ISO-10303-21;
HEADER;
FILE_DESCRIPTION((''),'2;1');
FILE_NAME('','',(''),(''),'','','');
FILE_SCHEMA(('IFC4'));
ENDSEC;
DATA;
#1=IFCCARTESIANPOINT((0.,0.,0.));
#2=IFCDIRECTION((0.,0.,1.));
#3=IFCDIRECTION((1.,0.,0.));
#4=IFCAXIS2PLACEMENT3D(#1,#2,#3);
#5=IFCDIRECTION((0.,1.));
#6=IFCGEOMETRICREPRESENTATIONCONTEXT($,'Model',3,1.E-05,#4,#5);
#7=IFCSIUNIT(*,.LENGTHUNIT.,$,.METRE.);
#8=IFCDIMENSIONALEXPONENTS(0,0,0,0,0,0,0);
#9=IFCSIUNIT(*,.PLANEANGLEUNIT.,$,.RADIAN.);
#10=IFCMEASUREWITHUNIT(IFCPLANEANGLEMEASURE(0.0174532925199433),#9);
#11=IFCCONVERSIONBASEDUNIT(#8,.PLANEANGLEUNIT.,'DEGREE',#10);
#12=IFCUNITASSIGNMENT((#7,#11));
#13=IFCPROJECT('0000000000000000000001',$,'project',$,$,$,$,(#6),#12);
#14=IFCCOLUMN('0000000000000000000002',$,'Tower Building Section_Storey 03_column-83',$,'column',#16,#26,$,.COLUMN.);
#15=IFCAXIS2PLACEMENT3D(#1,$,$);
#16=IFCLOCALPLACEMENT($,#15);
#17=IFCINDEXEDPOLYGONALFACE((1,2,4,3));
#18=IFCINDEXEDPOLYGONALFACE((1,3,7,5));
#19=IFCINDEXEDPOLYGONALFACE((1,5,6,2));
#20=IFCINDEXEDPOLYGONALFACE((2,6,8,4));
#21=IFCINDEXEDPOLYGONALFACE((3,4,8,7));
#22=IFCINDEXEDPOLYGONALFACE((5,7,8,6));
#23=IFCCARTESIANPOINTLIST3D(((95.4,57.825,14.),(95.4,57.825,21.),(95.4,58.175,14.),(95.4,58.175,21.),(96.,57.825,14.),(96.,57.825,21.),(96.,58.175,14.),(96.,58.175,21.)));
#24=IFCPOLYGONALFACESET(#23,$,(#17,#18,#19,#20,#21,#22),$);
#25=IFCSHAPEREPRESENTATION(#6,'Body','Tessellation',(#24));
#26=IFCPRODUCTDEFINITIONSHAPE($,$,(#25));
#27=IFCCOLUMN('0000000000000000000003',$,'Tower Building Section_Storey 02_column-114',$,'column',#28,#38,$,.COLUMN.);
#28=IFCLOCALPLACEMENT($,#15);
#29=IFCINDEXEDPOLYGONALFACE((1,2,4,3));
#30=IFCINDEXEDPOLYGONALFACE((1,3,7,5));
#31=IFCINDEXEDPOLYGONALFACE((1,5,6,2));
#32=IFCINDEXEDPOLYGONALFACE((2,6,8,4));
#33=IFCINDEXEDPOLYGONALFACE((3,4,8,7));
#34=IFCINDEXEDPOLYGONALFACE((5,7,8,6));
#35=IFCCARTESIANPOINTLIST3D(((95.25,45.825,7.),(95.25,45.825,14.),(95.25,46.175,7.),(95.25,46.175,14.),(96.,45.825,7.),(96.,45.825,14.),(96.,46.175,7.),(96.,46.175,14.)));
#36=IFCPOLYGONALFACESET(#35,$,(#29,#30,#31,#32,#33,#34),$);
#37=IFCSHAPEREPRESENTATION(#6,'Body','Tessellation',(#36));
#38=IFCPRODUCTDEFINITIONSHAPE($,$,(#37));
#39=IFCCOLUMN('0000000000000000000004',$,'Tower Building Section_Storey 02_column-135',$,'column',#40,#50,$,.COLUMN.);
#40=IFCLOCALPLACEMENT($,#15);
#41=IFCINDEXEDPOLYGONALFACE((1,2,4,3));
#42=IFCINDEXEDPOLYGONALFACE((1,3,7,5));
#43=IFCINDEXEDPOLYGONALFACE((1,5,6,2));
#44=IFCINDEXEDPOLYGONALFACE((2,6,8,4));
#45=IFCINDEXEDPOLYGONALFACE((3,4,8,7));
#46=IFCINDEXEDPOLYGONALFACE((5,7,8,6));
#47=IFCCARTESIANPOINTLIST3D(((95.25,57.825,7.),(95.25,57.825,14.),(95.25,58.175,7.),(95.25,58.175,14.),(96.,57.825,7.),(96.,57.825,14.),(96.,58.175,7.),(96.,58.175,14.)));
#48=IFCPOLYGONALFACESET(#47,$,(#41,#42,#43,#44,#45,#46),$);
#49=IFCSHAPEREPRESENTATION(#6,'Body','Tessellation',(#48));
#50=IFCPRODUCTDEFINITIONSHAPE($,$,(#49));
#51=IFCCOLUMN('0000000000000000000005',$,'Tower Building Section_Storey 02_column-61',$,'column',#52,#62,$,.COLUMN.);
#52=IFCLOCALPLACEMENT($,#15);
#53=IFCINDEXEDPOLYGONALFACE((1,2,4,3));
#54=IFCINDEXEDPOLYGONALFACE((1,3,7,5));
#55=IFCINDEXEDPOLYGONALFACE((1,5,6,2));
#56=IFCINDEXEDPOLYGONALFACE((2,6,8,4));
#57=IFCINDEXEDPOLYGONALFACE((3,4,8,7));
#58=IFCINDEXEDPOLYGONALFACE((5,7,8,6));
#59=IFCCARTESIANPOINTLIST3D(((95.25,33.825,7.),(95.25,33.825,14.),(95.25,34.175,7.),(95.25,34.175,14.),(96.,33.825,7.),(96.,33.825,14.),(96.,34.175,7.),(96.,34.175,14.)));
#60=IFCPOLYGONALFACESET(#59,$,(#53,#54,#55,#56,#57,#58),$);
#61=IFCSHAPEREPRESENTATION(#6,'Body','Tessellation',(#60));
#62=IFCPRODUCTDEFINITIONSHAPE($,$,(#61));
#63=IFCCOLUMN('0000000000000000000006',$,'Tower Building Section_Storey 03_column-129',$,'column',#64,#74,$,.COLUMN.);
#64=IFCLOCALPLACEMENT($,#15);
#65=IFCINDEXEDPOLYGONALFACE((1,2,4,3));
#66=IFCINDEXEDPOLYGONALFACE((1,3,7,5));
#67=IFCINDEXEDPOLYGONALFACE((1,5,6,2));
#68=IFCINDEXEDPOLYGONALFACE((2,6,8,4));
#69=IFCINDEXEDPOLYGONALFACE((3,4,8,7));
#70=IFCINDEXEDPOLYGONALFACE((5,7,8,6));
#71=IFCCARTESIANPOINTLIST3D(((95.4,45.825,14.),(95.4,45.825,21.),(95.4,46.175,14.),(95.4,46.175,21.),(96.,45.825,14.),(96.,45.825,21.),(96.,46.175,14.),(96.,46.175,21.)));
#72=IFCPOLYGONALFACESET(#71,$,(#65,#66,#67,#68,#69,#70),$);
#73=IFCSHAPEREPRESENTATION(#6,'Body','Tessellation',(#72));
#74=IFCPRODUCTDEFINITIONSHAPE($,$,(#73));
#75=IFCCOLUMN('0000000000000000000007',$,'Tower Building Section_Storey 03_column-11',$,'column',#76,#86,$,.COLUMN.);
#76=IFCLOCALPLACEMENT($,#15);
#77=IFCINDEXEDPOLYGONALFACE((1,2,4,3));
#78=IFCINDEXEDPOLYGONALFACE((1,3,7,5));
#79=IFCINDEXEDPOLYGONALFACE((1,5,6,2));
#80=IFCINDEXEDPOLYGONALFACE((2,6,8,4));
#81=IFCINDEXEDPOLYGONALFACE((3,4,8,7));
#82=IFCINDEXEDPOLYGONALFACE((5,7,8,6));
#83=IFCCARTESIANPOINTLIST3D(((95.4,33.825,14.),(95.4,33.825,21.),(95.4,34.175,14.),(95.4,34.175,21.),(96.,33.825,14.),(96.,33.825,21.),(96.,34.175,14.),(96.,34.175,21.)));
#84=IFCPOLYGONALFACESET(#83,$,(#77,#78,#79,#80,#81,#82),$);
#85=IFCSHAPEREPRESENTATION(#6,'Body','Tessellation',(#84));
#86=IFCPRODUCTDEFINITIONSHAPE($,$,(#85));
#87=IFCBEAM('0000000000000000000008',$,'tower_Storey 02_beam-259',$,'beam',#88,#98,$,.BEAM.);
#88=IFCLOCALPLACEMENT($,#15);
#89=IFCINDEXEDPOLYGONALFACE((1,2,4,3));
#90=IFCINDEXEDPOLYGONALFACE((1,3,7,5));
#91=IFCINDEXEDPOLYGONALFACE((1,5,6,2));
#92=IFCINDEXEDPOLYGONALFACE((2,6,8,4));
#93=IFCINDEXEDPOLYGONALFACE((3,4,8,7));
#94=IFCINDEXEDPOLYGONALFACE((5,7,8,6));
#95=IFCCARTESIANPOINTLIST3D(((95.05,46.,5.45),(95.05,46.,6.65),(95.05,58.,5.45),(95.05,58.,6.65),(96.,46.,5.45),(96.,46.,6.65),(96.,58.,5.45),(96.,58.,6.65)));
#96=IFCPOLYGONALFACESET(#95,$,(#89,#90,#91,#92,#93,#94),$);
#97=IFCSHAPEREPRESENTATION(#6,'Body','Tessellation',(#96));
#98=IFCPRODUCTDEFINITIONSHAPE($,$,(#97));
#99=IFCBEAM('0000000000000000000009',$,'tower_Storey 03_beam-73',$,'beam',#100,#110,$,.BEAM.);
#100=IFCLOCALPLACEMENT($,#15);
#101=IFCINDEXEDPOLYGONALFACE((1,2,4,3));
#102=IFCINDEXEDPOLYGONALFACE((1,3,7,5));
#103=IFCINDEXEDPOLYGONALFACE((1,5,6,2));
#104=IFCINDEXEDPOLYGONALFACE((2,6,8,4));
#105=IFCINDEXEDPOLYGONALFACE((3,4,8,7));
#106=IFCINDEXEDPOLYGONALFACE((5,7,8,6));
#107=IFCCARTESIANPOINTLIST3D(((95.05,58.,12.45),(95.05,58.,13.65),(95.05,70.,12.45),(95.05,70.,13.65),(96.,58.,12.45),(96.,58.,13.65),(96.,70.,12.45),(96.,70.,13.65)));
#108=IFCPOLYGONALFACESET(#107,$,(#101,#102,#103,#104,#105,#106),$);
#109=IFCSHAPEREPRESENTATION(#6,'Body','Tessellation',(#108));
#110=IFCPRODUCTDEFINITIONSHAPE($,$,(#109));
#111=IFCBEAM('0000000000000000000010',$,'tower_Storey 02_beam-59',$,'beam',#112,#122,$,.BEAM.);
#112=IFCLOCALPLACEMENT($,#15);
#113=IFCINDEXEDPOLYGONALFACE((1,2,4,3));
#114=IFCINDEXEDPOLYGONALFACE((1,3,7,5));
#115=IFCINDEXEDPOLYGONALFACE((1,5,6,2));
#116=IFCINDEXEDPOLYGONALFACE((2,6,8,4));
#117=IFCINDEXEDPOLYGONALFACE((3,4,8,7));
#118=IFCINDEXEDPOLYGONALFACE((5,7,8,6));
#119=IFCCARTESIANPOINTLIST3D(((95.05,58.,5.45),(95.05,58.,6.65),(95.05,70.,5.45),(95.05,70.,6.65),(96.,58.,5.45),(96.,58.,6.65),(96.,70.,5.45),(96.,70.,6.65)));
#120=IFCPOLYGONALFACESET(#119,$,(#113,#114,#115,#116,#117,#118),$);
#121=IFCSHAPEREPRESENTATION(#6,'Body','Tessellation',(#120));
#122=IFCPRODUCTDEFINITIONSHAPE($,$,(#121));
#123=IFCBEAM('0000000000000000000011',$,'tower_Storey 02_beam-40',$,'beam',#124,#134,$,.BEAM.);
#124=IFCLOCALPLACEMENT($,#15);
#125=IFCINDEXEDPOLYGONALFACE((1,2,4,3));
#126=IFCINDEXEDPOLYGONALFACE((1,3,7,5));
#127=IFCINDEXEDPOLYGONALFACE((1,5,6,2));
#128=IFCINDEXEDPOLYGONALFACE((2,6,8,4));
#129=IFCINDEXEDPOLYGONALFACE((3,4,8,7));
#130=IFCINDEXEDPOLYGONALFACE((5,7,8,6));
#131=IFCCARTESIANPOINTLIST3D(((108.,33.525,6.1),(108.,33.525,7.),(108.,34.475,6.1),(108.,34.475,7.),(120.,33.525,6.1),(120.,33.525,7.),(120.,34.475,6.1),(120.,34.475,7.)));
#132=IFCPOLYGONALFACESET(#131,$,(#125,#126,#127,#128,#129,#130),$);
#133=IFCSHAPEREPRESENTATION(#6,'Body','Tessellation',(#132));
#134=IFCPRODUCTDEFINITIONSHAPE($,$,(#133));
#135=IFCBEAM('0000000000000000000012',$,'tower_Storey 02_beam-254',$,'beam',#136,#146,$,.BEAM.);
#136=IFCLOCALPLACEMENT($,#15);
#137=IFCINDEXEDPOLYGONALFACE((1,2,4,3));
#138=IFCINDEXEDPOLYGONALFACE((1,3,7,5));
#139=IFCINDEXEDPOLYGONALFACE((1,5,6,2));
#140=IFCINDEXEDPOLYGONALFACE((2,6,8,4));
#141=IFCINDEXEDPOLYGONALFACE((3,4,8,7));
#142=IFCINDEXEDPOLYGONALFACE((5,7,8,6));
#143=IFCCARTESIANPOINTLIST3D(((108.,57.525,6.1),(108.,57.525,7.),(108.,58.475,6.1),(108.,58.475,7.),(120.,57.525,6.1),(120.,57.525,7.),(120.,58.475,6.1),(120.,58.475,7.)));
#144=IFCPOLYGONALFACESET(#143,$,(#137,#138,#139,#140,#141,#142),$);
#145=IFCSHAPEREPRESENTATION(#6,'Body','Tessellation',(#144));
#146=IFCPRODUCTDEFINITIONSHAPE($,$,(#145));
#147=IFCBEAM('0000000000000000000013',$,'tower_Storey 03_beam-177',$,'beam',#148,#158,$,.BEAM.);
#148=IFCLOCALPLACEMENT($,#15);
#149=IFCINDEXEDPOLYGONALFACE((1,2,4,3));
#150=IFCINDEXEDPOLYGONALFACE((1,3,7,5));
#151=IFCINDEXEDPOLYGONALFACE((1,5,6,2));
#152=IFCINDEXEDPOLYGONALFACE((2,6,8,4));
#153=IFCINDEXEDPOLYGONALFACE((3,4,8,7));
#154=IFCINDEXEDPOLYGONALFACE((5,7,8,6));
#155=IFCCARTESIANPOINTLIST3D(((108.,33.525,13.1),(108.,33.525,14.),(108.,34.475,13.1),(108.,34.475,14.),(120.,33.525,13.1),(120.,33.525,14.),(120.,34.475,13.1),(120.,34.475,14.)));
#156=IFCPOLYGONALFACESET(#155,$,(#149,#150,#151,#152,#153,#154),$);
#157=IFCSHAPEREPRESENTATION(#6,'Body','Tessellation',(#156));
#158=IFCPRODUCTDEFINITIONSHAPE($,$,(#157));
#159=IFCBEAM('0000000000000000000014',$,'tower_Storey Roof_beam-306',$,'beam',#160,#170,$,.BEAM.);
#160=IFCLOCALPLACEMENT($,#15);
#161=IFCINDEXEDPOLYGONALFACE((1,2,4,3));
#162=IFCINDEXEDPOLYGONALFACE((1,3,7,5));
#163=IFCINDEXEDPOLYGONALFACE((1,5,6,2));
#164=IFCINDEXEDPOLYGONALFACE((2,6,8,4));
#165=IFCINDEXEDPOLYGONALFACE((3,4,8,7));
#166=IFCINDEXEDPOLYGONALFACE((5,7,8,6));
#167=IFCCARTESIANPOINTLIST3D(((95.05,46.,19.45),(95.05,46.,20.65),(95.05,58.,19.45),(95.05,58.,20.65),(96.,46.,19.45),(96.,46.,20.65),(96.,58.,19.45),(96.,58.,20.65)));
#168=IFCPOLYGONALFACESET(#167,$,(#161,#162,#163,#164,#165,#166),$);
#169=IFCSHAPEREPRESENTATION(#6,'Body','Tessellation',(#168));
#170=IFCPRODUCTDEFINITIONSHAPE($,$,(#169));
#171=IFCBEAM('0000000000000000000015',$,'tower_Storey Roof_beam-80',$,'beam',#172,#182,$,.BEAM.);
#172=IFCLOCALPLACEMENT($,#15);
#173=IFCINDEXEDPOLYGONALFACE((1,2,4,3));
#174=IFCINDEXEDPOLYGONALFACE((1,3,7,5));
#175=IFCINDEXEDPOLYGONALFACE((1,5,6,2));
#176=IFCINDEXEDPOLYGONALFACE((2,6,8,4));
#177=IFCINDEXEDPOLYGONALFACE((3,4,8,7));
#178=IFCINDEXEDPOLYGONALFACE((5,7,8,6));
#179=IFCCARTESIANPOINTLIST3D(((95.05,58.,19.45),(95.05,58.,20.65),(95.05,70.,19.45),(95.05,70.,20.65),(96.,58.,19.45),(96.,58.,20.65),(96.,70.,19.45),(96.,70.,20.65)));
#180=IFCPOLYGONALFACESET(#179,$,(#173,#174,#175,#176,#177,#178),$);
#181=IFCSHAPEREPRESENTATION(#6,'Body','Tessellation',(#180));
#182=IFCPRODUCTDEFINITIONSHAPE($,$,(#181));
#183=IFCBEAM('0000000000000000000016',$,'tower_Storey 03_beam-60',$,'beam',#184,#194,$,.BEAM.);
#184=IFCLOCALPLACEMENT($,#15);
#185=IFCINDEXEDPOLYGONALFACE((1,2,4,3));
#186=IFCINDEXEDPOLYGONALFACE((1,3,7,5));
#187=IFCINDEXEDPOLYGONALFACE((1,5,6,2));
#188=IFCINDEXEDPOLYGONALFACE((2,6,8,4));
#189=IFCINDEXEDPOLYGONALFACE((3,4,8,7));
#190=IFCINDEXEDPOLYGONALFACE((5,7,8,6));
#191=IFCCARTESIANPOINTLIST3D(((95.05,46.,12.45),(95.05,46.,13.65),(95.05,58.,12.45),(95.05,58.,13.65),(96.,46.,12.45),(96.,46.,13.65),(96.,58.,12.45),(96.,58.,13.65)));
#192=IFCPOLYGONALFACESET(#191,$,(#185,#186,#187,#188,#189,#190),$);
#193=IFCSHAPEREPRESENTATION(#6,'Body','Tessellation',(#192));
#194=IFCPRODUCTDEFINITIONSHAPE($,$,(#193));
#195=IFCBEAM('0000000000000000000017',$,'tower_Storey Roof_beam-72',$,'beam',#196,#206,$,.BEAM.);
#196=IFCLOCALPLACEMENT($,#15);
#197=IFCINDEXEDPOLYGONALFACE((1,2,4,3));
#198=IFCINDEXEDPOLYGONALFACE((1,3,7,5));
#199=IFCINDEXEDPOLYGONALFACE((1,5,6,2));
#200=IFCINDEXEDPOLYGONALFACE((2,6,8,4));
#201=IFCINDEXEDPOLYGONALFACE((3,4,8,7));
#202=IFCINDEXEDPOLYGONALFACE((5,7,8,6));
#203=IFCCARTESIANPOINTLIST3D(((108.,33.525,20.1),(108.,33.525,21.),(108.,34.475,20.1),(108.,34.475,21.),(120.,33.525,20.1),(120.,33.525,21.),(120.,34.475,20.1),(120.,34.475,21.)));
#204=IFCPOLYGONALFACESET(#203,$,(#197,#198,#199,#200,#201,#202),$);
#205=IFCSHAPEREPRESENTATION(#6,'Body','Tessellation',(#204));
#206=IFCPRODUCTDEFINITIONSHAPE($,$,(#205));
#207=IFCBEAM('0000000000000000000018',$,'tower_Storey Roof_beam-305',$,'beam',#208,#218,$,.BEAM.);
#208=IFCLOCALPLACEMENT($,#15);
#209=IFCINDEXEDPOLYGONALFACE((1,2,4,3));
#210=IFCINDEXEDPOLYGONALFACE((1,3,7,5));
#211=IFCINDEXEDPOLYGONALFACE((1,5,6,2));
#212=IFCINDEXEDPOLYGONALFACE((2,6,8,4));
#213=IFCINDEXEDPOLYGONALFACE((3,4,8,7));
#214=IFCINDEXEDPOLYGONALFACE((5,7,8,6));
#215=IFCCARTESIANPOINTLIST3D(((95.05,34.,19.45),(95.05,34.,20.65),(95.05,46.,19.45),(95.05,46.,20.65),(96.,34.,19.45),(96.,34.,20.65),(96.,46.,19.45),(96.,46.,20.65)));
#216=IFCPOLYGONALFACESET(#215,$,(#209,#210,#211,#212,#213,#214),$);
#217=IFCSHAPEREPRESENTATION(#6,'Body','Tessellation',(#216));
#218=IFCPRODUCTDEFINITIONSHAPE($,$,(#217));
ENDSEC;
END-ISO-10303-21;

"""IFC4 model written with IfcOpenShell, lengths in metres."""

from ifc_helpers import new_model, entity, si_unit, converted_unit, direction, frame, origin_with_axes, place, context, project, polyline, outline, extrude, element, save


model = new_model("IFC4")

# Units and contexts
model_context = context("Model", 3, precision=1e-05, world=origin_with_axes(), true_north=direction((0.0, 1.0)))
ifc_project = project(units=[si_unit("LENGTHUNIT", "METRE"), converted_unit("PLANEANGLEUNIT", "DEGREE", entity("IfcPlaneAngleMeasure", 0.0174532925199433), si_unit("PLANEANGLEUNIT", "RADIAN"), dimensions=[0, 0, 0, 0, 0, 0, 0])], contexts=[model_context])

# Columns
placement_1 = place(None, origin_with_axes())
placement_2 = place(placement_1, frame((0.0, 0.0, 14.0), z_axis=(0.0, 0.0, 1.0), x_axis=(1.0, 0.0, 0.0)))
column_placement = place(placement_2, frame((95.7, 58.0, 0.0), z_axis=(0.0, 0.0, 1.0), x_axis=(1.0, 0.0, 0.0)))
element("IfcColumn", 1, at=column_placement, Name="Tower Building Section_Storey 03_column-83", ObjectType="column", PredefinedType="COLUMN", context=model_context, body=[
    extrude(outline(polyline([(-0.3, -0.175, 0.0), (0.3, -0.175, 0.0), (0.3, 0.175, 0.0), (-0.3, 0.175, 0.0), (-0.3, -0.175, 0.0)])), origin_with_axes(), (0.0, 0.0, 1.0), 7.0),
])
placement_3 = place(placement_1, frame((0.0, 0.0, 7.0), z_axis=(0.0, 0.0, 1.0), x_axis=(1.0, 0.0, 0.0)))
for number, where, z_axis, x_axis, name in (
    (2, (95.625, 46.0, 0.0), (0.0, 0.0, 1.0), (1.0, 0.0, 0.0), "Tower Building Section_Storey 02_column-114"),
    (3, (95.625, 58.0, 0.0), (0.0, 0.0, 1.0), (1.0, 0.0, 0.0), "Tower Building Section_Storey 02_column-135"),
    (4, (95.625, 34.0, 0.0), (0.0, 0.0, 1.0), (1.0, 0.0, 0.0), "Tower Building Section_Storey 02_column-61"),
):
    element("IfcColumn", number, at=place(placement_3, frame(where, z_axis=z_axis, x_axis=x_axis)), Name=name, ObjectType="column", PredefinedType="COLUMN", context=model_context, body=[
        extrude(outline(polyline([(-0.375, -0.175, 0.0), (0.375, -0.175, 0.0), (0.375, 0.175, 0.0), (-0.375, 0.175, 0.0), (-0.375, -0.175, 0.0)])), origin_with_axes(), (0.0, 0.0, 1.0), 7.0),
    ])
for number, where, z_axis, x_axis, name in (
    (5, (95.7, 46.0, 0.0), (0.0, 0.0, 1.0), (1.0, 0.0, 0.0), "Tower Building Section_Storey 03_column-129"),
    (6, (95.7, 34.0, 0.0), (0.0, 0.0, 1.0), (1.0, 0.0, 0.0), "Tower Building Section_Storey 03_column-11"),
):
    element("IfcColumn", number, at=place(placement_2, frame(where, z_axis=z_axis, x_axis=x_axis)), Name=name, ObjectType="column", PredefinedType="COLUMN", context=model_context, body=[
        extrude(outline(polyline([(-0.3, -0.175, 0.0), (0.3, -0.175, 0.0), (0.3, 0.175, 0.0), (-0.3, 0.175, 0.0), (-0.3, -0.175, 0.0)])), origin_with_axes(), (0.0, 0.0, 1.0), 7.0),
    ])

# Beams
beam_1_placement = place(placement_3, frame((95.525, 46.0, -0.95), z_axis=(0.0, 1.0, 0.0), x_axis=(-1.0, 0.0, 0.0)))
element("IfcBeam", 7, at=beam_1_placement, Name="tower_Storey 02_beam-259", ObjectType="beam", PredefinedType="BEAM", context=model_context, body=[
    extrude(outline(polyline([(0.475, 0.6, 0.0), (-0.475, 0.6, 0.0), (-0.475, -0.6, 0.0), (0.475, -0.6, 0.0), (0.475, 0.6, 0.0)])), origin_with_axes(), (0.0, 0.0, 1.0), 12.0),
])
beam_2_placement = place(placement_2, frame((95.525, 58.0, -0.95), z_axis=(0.0, 1.0, 0.0), x_axis=(-1.0, 0.0, 0.0)))
element("IfcBeam", 8, at=beam_2_placement, Name="tower_Storey 03_beam-73", ObjectType="beam", PredefinedType="BEAM", context=model_context, body=[
    extrude(outline(polyline([(0.475, 0.6, 0.0), (-0.475, 0.6, 0.0), (-0.475, -0.6, 0.0), (0.475, -0.6, 0.0), (0.475, 0.6, 0.0)])), origin_with_axes(), (0.0, 0.0, 1.0), 12.0),
])
beam_3_placement = place(placement_3, frame((95.525, 58.0, -0.95), z_axis=(0.0, 1.0, 0.0), x_axis=(-1.0, 0.0, 0.0)))
element("IfcBeam", 9, at=beam_3_placement, Name="tower_Storey 02_beam-59", ObjectType="beam", PredefinedType="BEAM", context=model_context, body=[
    extrude(outline(polyline([(0.475, 0.6, 0.0), (-0.475, 0.6, 0.0), (-0.475, -0.6, 0.0), (0.475, -0.6, 0.0), (0.475, 0.6, 0.0)])), origin_with_axes(), (0.0, 0.0, 1.0), 12.0),
])
for number, where, z_axis, x_axis, name in (
    (10, (108.0, 34.0, -0.45), (1.0, 0.0, 0.0), (0.0, 1.0, 0.0), "tower_Storey 02_beam-40"),
    (11, (108.0, 58.0, -0.45), (1.0, 0.0, 0.0), (0.0, 1.0, 0.0), "tower_Storey 02_beam-254"),
):
    element("IfcBeam", number, at=place(placement_3, frame(where, z_axis=z_axis, x_axis=x_axis)), Name=name, ObjectType="beam", PredefinedType="BEAM", context=model_context, body=[
        extrude(outline(polyline([(0.475, 0.45, 0.0), (-0.475, 0.45, 0.0), (-0.475, -0.45, 0.0), (0.475, -0.45, 0.0), (0.475, 0.45, 0.0)])), origin_with_axes(), (0.0, 0.0, 1.0), 12.0),
    ])
beam_4_placement = place(placement_2, frame((108.0, 34.0, -0.45), z_axis=(1.0, 0.0, 0.0), x_axis=(0.0, 1.0, 0.0)))
element("IfcBeam", 12, at=beam_4_placement, Name="tower_Storey 03_beam-177", ObjectType="beam", PredefinedType="BEAM", context=model_context, body=[
    extrude(outline(polyline([(0.475, 0.45, 0.0), (-0.475, 0.45, 0.0), (-0.475, -0.45, 0.0), (0.475, -0.45, 0.0), (0.475, 0.45, 0.0)])), origin_with_axes(), (0.0, 0.0, 1.0), 12.0),
])
placement_4 = place(placement_1, frame((0.0, 0.0, 21.0), z_axis=(0.0, 0.0, 1.0), x_axis=(1.0, 0.0, 0.0)))
for number, where, z_axis, x_axis, name in (
    (13, (95.525, 46.0, -0.95), (0.0, 1.0, 0.0), (-1.0, 0.0, 0.0), "tower_Storey Roof_beam-306"),
    (14, (95.525, 58.0, -0.95), (0.0, 1.0, 0.0), (-1.0, 0.0, 0.0), "tower_Storey Roof_beam-80"),
):
    element("IfcBeam", number, at=place(placement_4, frame(where, z_axis=z_axis, x_axis=x_axis)), Name=name, ObjectType="beam", PredefinedType="BEAM", context=model_context, body=[
        extrude(outline(polyline([(0.475, 0.6, 0.0), (-0.475, 0.6, 0.0), (-0.475, -0.6, 0.0), (0.475, -0.6, 0.0), (0.475, 0.6, 0.0)])), origin_with_axes(), (0.0, 0.0, 1.0), 12.0),
    ])
beam_5_placement = place(placement_2, frame((95.525, 46.0, -0.95), z_axis=(0.0, 1.0, 0.0), x_axis=(-1.0, 0.0, 0.0)))
element("IfcBeam", 15, at=beam_5_placement, Name="tower_Storey 03_beam-60", ObjectType="beam", PredefinedType="BEAM", context=model_context, body=[
    extrude(outline(polyline([(0.475, 0.6, 0.0), (-0.475, 0.6, 0.0), (-0.475, -0.6, 0.0), (0.475, -0.6, 0.0), (0.475, 0.6, 0.0)])), origin_with_axes(), (0.0, 0.0, 1.0), 12.0),
])
beam_6_placement = place(placement_4, frame((108.0, 34.0, -0.45), z_axis=(1.0, 0.0, 0.0), x_axis=(0.0, 1.0, 0.0)))
element("IfcBeam", 16, at=beam_6_placement, Name="tower_Storey Roof_beam-72", ObjectType="beam", PredefinedType="BEAM", context=model_context, body=[
    extrude(outline(polyline([(0.475, 0.45, 0.0), (-0.475, 0.45, 0.0), (-0.475, -0.45, 0.0), (0.475, -0.45, 0.0), (0.475, 0.45, 0.0)])), origin_with_axes(), (0.0, 0.0, 1.0), 12.0),
])
beam_7_placement = place(placement_4, frame((95.525, 34.0, -0.95), z_axis=(0.0, 1.0, 0.0), x_axis=(-1.0, 0.0, 0.0)))
element("IfcBeam", 17, at=beam_7_placement, Name="tower_Storey Roof_beam-305", ObjectType="beam", PredefinedType="BEAM", context=model_context, body=[
    extrude(outline(polyline([(0.475, 0.6, 0.0), (-0.475, 0.6, 0.0), (-0.475, -0.6, 0.0), (0.475, -0.6, 0.0), (0.475, 0.6, 0.0)])), origin_with_axes(), (0.0, 0.0, 1.0), 12.0),
])

save(model, "model.ifc")
